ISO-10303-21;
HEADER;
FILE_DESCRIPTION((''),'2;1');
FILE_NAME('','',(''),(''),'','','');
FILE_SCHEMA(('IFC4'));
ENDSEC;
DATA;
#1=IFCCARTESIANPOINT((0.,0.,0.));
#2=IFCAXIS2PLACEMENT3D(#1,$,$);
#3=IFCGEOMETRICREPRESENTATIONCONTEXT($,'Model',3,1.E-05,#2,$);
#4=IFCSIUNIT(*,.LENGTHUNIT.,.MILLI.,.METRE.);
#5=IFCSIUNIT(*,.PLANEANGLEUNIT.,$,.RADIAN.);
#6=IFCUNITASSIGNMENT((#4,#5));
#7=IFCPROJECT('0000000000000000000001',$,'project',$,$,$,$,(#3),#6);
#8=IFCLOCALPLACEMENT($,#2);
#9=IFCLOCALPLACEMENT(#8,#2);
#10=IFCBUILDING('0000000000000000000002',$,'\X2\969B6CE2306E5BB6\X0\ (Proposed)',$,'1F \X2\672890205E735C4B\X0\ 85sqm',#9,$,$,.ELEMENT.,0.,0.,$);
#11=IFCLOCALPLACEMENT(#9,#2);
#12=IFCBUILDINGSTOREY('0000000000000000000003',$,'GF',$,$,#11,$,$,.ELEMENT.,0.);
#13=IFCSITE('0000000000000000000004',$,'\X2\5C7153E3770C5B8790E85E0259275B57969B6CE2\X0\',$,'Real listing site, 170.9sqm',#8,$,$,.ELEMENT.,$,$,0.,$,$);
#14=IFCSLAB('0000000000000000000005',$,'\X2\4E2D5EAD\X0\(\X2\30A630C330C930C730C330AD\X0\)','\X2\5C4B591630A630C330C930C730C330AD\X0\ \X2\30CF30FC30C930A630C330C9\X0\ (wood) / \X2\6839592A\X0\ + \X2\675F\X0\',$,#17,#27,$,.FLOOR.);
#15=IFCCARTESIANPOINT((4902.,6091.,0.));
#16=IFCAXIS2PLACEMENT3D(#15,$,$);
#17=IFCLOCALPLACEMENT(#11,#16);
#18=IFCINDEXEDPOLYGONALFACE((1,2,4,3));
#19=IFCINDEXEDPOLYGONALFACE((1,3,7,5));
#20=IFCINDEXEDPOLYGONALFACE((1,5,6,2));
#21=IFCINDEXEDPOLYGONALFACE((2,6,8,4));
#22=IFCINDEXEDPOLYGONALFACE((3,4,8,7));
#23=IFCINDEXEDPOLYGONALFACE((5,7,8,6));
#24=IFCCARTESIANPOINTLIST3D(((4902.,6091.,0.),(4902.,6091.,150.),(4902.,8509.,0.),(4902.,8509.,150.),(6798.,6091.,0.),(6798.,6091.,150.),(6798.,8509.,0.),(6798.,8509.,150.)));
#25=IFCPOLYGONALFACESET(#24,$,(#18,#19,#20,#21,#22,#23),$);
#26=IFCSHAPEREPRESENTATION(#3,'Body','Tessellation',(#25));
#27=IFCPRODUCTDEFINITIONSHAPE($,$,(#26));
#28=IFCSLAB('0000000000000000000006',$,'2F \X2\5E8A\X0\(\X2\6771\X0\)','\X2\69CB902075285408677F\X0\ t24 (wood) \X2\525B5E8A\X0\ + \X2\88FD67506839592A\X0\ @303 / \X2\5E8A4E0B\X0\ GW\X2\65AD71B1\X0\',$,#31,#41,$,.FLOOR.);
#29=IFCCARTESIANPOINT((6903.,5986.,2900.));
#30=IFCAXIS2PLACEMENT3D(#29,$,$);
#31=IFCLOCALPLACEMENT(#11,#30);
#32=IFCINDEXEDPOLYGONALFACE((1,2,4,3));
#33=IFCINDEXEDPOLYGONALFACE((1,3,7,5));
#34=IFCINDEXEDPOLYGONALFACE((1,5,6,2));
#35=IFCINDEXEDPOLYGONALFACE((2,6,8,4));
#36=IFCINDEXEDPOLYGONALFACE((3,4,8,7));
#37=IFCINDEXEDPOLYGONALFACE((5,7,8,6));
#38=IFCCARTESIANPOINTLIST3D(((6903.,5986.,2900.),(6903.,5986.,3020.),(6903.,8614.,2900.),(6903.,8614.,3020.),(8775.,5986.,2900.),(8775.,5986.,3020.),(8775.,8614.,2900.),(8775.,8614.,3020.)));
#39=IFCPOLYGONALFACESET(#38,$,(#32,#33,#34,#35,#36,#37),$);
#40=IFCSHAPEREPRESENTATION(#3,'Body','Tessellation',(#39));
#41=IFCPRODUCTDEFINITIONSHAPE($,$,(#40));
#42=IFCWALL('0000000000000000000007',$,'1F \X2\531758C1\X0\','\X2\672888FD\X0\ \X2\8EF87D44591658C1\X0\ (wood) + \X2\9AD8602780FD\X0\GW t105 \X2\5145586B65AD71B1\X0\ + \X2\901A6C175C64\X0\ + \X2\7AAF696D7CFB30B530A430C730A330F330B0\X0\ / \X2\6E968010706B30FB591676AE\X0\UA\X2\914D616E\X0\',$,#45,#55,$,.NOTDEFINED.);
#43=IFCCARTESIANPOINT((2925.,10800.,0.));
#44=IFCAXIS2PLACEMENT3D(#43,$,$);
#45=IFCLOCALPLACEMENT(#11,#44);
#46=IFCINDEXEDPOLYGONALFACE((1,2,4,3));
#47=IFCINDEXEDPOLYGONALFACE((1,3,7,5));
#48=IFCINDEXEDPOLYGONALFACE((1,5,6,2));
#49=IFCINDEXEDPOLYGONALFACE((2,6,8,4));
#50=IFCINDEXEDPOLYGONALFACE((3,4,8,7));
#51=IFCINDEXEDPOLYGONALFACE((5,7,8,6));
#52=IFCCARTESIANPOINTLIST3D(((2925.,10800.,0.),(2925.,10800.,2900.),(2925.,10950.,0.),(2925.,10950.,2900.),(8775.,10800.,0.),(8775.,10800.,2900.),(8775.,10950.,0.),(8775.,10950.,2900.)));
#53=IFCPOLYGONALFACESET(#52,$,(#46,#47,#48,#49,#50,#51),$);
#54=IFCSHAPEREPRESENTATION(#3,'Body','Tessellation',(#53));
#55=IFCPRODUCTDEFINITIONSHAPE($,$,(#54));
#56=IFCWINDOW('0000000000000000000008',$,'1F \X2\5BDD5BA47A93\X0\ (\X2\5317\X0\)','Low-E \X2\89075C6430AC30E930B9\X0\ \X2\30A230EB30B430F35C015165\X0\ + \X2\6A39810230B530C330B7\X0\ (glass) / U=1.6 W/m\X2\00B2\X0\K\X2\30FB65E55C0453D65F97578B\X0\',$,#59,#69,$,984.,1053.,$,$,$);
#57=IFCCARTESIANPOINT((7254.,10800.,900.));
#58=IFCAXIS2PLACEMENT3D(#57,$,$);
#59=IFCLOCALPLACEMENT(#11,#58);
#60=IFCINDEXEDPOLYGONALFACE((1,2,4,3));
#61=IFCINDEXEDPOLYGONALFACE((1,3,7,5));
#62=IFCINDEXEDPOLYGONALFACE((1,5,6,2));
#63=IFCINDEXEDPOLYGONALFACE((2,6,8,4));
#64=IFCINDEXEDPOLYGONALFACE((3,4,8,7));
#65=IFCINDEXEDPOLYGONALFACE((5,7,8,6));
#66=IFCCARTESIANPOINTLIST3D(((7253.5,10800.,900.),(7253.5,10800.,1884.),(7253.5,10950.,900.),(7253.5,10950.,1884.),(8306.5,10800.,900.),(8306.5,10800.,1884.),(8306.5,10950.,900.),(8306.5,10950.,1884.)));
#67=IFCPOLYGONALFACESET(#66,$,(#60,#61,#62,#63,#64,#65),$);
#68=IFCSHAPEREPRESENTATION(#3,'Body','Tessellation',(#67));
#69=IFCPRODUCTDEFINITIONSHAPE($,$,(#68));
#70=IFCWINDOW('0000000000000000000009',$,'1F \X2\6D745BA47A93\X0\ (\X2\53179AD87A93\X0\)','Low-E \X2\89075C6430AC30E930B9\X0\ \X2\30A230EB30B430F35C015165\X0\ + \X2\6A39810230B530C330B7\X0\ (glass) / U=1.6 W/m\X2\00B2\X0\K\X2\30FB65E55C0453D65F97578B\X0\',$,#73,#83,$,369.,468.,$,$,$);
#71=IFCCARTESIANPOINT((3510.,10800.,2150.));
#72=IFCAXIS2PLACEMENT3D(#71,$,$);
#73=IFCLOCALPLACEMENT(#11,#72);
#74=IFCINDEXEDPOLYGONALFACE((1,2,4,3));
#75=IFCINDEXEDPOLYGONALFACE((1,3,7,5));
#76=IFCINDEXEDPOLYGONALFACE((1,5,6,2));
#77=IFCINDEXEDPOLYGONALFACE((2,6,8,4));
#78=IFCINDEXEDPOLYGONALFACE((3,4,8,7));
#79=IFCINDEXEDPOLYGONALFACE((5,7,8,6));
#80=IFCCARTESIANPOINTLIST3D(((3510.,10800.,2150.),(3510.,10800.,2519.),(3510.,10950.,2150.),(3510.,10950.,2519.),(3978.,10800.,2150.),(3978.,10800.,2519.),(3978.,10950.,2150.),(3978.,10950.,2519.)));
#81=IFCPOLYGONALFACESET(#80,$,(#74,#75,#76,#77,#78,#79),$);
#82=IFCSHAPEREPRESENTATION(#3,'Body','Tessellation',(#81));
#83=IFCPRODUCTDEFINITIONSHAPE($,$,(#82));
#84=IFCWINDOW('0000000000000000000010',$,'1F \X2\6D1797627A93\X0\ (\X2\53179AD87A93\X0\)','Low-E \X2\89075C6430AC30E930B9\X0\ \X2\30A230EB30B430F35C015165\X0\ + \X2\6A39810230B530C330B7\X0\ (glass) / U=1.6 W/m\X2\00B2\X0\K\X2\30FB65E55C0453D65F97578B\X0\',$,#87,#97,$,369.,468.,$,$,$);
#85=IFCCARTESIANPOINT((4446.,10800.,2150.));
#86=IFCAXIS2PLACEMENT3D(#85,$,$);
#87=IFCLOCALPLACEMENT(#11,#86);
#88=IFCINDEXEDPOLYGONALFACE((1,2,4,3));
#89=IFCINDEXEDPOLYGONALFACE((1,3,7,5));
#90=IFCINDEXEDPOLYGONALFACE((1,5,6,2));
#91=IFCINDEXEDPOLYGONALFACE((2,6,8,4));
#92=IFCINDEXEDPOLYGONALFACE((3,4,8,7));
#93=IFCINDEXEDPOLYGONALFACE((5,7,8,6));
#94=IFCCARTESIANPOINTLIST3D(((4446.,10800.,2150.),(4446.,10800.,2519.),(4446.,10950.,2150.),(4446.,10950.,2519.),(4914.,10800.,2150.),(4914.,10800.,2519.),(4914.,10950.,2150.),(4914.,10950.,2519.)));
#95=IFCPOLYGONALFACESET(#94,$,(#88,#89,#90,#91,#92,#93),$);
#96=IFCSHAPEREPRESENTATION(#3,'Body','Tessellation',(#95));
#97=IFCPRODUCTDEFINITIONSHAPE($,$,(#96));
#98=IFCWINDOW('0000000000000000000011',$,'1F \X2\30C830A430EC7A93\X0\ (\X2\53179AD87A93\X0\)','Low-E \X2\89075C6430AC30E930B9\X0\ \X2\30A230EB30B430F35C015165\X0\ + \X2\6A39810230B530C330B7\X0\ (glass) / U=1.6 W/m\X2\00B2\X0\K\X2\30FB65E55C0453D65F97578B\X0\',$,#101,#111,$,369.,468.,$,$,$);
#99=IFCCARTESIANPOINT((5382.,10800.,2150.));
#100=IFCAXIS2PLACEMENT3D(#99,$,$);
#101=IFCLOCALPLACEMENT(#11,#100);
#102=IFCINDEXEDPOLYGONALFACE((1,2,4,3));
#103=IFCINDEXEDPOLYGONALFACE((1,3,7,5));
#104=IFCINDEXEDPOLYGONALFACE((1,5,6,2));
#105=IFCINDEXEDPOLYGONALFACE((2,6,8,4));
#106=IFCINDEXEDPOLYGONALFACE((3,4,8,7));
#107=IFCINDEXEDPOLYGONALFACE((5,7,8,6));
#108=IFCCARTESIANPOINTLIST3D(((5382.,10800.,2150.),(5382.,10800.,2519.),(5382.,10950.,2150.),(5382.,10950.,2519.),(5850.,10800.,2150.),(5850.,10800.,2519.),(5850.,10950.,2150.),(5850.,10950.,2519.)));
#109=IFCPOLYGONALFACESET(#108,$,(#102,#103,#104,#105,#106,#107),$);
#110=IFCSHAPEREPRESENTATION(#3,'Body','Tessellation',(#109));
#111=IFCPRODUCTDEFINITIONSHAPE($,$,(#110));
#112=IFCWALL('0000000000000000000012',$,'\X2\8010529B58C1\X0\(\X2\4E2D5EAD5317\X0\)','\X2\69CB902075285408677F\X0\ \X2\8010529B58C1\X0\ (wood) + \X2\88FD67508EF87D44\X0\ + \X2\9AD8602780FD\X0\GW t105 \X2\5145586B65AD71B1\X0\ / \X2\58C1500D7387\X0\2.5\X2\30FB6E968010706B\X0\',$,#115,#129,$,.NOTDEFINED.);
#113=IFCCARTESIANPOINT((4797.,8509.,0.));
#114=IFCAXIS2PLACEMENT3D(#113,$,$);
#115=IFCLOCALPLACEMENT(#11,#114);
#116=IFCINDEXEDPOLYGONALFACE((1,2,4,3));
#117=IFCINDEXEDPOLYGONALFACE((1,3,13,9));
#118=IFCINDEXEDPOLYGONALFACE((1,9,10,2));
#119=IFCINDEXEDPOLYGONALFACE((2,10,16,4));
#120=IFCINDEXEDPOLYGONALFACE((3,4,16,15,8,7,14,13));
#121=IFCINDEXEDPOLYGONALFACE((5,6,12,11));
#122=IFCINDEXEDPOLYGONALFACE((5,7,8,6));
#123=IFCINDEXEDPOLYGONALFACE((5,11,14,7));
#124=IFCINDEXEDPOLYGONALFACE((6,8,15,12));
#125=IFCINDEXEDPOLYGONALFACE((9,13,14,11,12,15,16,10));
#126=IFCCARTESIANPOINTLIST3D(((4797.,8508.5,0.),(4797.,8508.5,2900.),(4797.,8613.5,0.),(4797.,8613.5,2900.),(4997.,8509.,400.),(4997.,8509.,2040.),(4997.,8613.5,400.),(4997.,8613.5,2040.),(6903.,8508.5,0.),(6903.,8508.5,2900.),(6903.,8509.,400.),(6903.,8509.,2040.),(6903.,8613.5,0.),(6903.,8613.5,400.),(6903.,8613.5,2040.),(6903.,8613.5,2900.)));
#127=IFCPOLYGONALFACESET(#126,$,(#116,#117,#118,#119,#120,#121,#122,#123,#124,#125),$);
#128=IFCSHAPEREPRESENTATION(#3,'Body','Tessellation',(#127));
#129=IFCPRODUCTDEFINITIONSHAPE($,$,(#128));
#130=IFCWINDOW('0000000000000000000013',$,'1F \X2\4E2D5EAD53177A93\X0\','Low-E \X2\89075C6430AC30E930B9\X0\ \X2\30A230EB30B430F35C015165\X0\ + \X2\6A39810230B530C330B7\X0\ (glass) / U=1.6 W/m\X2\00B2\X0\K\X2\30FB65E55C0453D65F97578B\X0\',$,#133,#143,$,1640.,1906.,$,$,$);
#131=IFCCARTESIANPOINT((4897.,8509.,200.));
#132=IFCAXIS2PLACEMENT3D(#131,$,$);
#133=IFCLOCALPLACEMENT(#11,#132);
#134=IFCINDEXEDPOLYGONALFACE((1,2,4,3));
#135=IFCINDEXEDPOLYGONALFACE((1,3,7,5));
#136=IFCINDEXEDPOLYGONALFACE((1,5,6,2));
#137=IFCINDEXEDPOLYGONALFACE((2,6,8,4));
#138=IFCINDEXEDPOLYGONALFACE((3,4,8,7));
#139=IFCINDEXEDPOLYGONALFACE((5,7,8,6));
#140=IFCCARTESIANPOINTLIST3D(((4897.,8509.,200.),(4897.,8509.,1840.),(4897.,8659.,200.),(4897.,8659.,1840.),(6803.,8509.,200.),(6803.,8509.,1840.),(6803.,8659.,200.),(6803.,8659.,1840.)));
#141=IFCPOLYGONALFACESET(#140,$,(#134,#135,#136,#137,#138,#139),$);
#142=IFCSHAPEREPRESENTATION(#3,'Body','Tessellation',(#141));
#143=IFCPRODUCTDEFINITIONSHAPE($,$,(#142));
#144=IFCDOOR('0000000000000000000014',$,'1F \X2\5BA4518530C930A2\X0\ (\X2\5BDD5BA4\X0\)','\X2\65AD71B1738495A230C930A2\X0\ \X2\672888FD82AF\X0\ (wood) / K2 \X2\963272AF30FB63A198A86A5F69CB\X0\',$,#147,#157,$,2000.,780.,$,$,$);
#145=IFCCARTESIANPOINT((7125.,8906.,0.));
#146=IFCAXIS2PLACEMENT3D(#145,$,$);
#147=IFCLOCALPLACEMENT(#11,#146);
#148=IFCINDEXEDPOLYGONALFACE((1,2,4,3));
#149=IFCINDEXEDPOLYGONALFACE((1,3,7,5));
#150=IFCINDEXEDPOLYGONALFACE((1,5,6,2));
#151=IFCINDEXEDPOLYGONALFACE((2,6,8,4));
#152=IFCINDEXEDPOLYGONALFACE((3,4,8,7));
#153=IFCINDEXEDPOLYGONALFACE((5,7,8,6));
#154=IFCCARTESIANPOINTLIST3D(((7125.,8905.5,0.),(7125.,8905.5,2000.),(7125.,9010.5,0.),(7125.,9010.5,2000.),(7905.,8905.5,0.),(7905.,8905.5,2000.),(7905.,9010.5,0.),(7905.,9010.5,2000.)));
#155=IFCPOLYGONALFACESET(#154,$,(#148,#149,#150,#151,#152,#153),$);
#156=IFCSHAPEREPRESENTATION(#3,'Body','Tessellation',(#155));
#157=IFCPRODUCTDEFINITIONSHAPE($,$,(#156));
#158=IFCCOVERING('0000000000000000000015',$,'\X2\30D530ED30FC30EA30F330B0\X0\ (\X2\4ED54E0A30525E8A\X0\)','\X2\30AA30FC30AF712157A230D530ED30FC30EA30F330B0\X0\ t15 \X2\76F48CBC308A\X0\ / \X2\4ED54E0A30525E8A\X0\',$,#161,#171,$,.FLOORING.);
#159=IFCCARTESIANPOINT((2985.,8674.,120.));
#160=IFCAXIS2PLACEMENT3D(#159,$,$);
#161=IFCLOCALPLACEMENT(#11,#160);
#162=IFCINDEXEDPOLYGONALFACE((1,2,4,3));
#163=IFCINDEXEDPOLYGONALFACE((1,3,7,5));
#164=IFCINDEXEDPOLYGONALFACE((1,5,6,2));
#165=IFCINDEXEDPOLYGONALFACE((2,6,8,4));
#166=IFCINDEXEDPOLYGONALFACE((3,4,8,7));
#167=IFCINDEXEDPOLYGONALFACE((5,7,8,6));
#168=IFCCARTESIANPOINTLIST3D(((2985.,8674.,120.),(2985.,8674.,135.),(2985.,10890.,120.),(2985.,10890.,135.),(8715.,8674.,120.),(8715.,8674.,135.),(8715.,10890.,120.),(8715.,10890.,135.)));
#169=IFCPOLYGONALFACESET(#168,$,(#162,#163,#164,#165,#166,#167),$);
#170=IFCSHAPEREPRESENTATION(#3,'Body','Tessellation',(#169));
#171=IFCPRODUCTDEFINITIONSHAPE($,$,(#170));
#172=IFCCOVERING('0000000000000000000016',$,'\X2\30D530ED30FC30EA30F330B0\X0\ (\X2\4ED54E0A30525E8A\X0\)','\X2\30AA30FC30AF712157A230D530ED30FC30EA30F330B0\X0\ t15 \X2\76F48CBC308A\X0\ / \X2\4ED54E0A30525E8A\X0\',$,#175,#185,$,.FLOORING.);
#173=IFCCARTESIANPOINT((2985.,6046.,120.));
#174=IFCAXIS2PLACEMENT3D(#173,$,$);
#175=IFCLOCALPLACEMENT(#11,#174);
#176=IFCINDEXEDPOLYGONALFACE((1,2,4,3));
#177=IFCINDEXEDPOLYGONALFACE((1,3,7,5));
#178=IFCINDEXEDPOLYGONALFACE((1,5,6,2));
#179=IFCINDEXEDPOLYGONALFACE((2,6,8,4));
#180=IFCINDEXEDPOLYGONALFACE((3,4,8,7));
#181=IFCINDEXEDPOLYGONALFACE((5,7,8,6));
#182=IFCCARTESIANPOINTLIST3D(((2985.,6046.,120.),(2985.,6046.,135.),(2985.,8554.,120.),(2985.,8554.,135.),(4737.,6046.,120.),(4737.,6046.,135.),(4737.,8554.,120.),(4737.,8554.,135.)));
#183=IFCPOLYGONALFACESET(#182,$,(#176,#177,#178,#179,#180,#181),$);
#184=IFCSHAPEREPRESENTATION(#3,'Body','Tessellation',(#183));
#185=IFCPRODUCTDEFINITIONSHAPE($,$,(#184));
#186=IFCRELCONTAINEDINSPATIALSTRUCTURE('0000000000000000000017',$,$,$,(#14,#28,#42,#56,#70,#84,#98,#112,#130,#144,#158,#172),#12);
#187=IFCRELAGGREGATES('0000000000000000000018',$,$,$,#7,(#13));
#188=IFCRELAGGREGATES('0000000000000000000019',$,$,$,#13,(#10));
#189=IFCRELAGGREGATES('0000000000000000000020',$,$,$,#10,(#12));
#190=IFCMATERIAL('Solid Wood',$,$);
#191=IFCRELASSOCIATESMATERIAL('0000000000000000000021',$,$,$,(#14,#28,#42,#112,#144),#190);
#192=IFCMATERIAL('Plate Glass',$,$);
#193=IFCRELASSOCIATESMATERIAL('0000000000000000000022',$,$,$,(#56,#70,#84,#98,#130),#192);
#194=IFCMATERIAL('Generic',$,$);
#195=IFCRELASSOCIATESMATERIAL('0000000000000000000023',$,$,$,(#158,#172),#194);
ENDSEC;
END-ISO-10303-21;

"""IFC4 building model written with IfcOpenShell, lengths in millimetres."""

from ifc_helpers import new_model, si_unit, frame, frame_2d, origin, place, context, project, spatial, rectangle, extrude, material, element, fill, save


model = new_model("IFC4")

# Units and contexts
model_context = context("Model", 3, precision=1e-05, world=origin())
ifc_project = project(units=[si_unit("LENGTHUNIT", "METRE", prefix="MILLI"), si_unit("PLANEANGLEUNIT", "RADIAN")], contexts=[model_context])

# Site, building, storey
site_placement = place(None, origin())
site = spatial("IfcSite", under=ifc_project, at=site_placement, Name="山口県宇部市大字際波", ObjectType="Real listing site, 170.9sqm", CompositionType="ELEMENT", RefElevation=0.0)
building_placement = place(site_placement, origin())
building = spatial("IfcBuilding", under=site, at=building_placement, Name="際波の家 (Proposed)", ObjectType="1F 木造平屋 85sqm", CompositionType="ELEMENT", ElevationOfRefHeight=0.0, ElevationOfTerrain=0.0)
storey_placement = place(building_placement, origin())
storey = spatial("IfcBuildingStorey", under=building, at=storey_placement, Name="GF", CompositionType="ELEMENT", Elevation=0.0)

# Slabs
ifc_material_1 = material(Name="Solid Wood")
slab_1_placement = place(storey_placement, frame((4902.0, 6091.0, 0.0)))
element("IfcSlab", 1, at=slab_1_placement, inside=storey, material=ifc_material_1, Name="中庭(ウッドデッキ)", Description="屋外ウッドデッキ ハードウッド (wood) / 根太 + 束", PredefinedType="FLOOR", context=model_context, shape_type="SweptSolid", body=[
    extrude(rectangle(XDim=1896.0, YDim=2418.0, at=frame_2d((948.0, 1209.0))), frame((4902.0, 6091.0, 0.0)), (0.0, 0.0, 1.0), 150.0),
])
slab_2_placement = place(storey_placement, frame((6903.0, 5986.0, 2900.0)))
element("IfcSlab", 2, at=slab_2_placement, inside=storey, material=ifc_material_1, Name="2F 床(東)", Description="構造用合板 t24 (wood) 剛床 + 製材根太 @303 / 床下 GW断熱", PredefinedType="FLOOR", context=model_context, shape_type="SweptSolid", body=[
    extrude(rectangle(XDim=1872.0, YDim=2628.0, at=frame_2d((936.0, 1314.0))), frame((6903.0, 5986.0, 2900.0)), (0.0, 0.0, 1.0), 120.0),
])

# Wall, openings, windows
wall_1_placement = place(storey_placement, frame((2925.0, 10800.0, 0.0)))
wall_1 = element("IfcWall", 3, at=wall_1_placement, inside=storey, material=ifc_material_1, Name="1F 北壁", Description="木製 軸組外壁 (wood) + 高性能GW t105 充填断熱 + 通気層 + 窯業系サイディング / 準耐火・外皮UA配慮", PredefinedType="NOTDEFINED", context=model_context, shape_type="SweptSolid", body=[
    extrude(rectangle(XDim=5850.0, YDim=150.0, at=frame_2d((2925.0, 75.0))), frame((2925.0, 10800.0, 0.0)), (0.0, 0.0, 1.0), 2900.0),
])
opening_1_placement = place(storey_placement, frame((7254.0, 10800.0, 900.0)))
opening_1 = element("IfcOpeningElement", 4, at=opening_1_placement, cuts=wall_1, PredefinedType="NOTDEFINED", context=model_context, shape_type="SweptSolid", body=[
    extrude(rectangle(XDim=1053.0, YDim=150.0, at=frame_2d((526.0, 75.0))), frame((7254.0, 10800.0, 900.0)), (0.0, 0.0, 1.0), 984.0),
])
opening_2_placement = place(storey_placement, frame((3510.0, 10800.0, 2150.0)))
opening_2 = element("IfcOpeningElement", 5, at=opening_2_placement, cuts=wall_1, PredefinedType="NOTDEFINED", context=model_context, shape_type="SweptSolid", body=[
    extrude(rectangle(XDim=468.0, YDim=150.0, at=frame_2d((234.0, 75.0))), frame((3510.0, 10800.0, 2150.0)), (0.0, 0.0, 1.0), 369.0),
])
opening_3_placement = place(storey_placement, frame((4446.0, 10800.0, 2150.0)))
opening_3 = element("IfcOpeningElement", 6, at=opening_3_placement, cuts=wall_1, PredefinedType="NOTDEFINED", context=model_context, shape_type="SweptSolid", body=[
    extrude(rectangle(XDim=468.0, YDim=150.0, at=frame_2d((234.0, 75.0))), frame((4446.0, 10800.0, 2150.0)), (0.0, 0.0, 1.0), 369.0),
])
opening_4_placement = place(storey_placement, frame((5382.0, 10800.0, 2150.0)))
opening_4 = element("IfcOpeningElement", 7, at=opening_4_placement, cuts=wall_1, PredefinedType="NOTDEFINED", context=model_context, shape_type="SweptSolid", body=[
    extrude(rectangle(XDim=468.0, YDim=150.0, at=frame_2d((234.0, 75.0))), frame((5382.0, 10800.0, 2150.0)), (0.0, 0.0, 1.0), 369.0),
])
ifc_material_2 = material(Name="Plate Glass")
window_1_placement = place(storey_placement, frame((7254.0, 10800.0, 900.0)))
window_1 = element("IfcWindow", 8, at=window_1_placement, inside=storey, material=ifc_material_2, Name="1F 寝室窓 (北)", Description="Low-E 複層ガラス アルゴン封入 + 樹脂サッシ (glass) / U=1.6 W/m²K・日射取得型", OverallHeight=984.0, OverallWidth=1053.0, context=model_context, shape_type="SweptSolid", body=[
    extrude(rectangle(XDim=1053.0, YDim=150.0, at=frame_2d((526.0, 75.0))), frame((7254.0, 10800.0, 900.0)), (0.0, 0.0, 1.0), 984.0),
])
fill(opening_1, window_1)
window_2_placement = place(storey_placement, frame((3510.0, 10800.0, 2150.0)))
window_2 = element("IfcWindow", 9, at=window_2_placement, inside=storey, material=ifc_material_2, Name="1F 浴室窓 (北高窓)", Description="Low-E 複層ガラス アルゴン封入 + 樹脂サッシ (glass) / U=1.6 W/m²K・日射取得型", OverallHeight=369.0, OverallWidth=468.0, context=model_context, shape_type="SweptSolid", body=[
    extrude(rectangle(XDim=468.0, YDim=150.0, at=frame_2d((234.0, 75.0))), frame((3510.0, 10800.0, 2150.0)), (0.0, 0.0, 1.0), 369.0),
])
fill(opening_2, window_2)
window_3_placement = place(storey_placement, frame((4446.0, 10800.0, 2150.0)))
window_3 = element("IfcWindow", 10, at=window_3_placement, inside=storey, material=ifc_material_2, Name="1F 洗面窓 (北高窓)", Description="Low-E 複層ガラス アルゴン封入 + 樹脂サッシ (glass) / U=1.6 W/m²K・日射取得型", OverallHeight=369.0, OverallWidth=468.0, context=model_context, shape_type="SweptSolid", body=[
    extrude(rectangle(XDim=468.0, YDim=150.0, at=frame_2d((234.0, 75.0))), frame((4446.0, 10800.0, 2150.0)), (0.0, 0.0, 1.0), 369.0),
])
fill(opening_3, window_3)
window_4_placement = place(storey_placement, frame((5382.0, 10800.0, 2150.0)))
window_4 = element("IfcWindow", 11, at=window_4_placement, inside=storey, material=ifc_material_2, Name="1F トイレ窓 (北高窓)", Description="Low-E 複層ガラス アルゴン封入 + 樹脂サッシ (glass) / U=1.6 W/m²K・日射取得型", OverallHeight=369.0, OverallWidth=468.0, context=model_context, shape_type="SweptSolid", body=[
    extrude(rectangle(XDim=468.0, YDim=150.0, at=frame_2d((234.0, 75.0))), frame((5382.0, 10800.0, 2150.0)), (0.0, 0.0, 1.0), 369.0),
])
fill(opening_4, window_4)

# Wall, opening, window
wall_2_placement = place(storey_placement, frame((4797.0, 8509.0, 0.0)))
wall_2 = element("IfcWall", 12, at=wall_2_placement, inside=storey, material=ifc_material_1, Name="耐力壁(中庭北)", Description="構造用合板 耐力壁 (wood) + 製材軸組 + 高性能GW t105 充填断熱 / 壁倍率2.5・準耐火", PredefinedType="NOTDEFINED", context=model_context, shape_type="SweptSolid", body=[
    extrude(rectangle(XDim=2106.0, YDim=105.0, at=frame_2d((1053.0, 52.0))), frame((4797.0, 8509.0, 0.0)), (0.0, 0.0, 1.0), 2900.0),
])
opening_5_placement = place(storey_placement, frame((4897.0, 8509.0, 200.0)))
opening_5 = element("IfcOpeningElement", 13, at=opening_5_placement, cuts=wall_2, PredefinedType="NOTDEFINED", context=model_context, shape_type="SweptSolid", body=[
    extrude(rectangle(XDim=1906.0, YDim=150.0, at=frame_2d((953.0, 75.0))), frame((4897.0, 8509.0, 200.0)), (0.0, 0.0, 1.0), 1640.0),
])
window_5_placement = place(storey_placement, frame((4897.0, 8509.0, 200.0)))
window_5 = element("IfcWindow", 14, at=window_5_placement, inside=storey, material=ifc_material_2, Name="1F 中庭北窓", Description="Low-E 複層ガラス アルゴン封入 + 樹脂サッシ (glass) / U=1.6 W/m²K・日射取得型", OverallHeight=1640.0, OverallWidth=1906.0, context=model_context, shape_type="SweptSolid", body=[
    extrude(rectangle(XDim=1906.0, YDim=150.0, at=frame_2d((953.0, 75.0))), frame((4897.0, 8509.0, 200.0)), (0.0, 0.0, 1.0), 1640.0),
])
fill(opening_5, window_5)

# Door
door_1_placement = place(storey_placement, frame((7125.0, 8906.0, 0.0)))
element("IfcDoor", 15, at=door_1_placement, inside=storey, material=ifc_material_1, Name="1F 室内ドア (寝室)", Description="断熱玄関ドア 木製芯 (wood) / K2 防犯・採風機構", OverallHeight=2000.0, OverallWidth=780.0, context=model_context, shape_type="SweptSolid", body=[
    extrude(rectangle(XDim=780.0, YDim=105.0, at=frame_2d((390.0, 52.0))), frame((7125.0, 8906.0, 0.0)), (0.0, 0.0, 1.0), 2000.0),
])

# Coverings
ifc_material_3 = material(Name="Generic")
covering_1_placement = place(storey_placement, frame((2985.0, 8674.0, 120.0)))
element("IfcCovering", 16, at=covering_1_placement, inside=storey, material=ifc_material_3, Name="フローリング (仕上げ床)", Description="オーク無垢フローリング t15 直貼り / 仕上げ床", PredefinedType="FLOORING", context=model_context, shape_type="SweptSolid", body=[
    extrude(rectangle(XDim=5730.0, YDim=2216.0, at=frame_2d((2865.0, 1108.0))), frame((2985.0, 8674.0, 120.0)), (0.0, 0.0, 1.0), 15.0),
])
covering_2_placement = place(storey_placement, frame((2985.0, 6046.0, 120.0)))
element("IfcCovering", 17, at=covering_2_placement, inside=storey, material=ifc_material_3, Name="フローリング (仕上げ床)", Description="オーク無垢フローリング t15 直貼り / 仕上げ床", PredefinedType="FLOORING", context=model_context, shape_type="SweptSolid", body=[
    extrude(rectangle(XDim=1752.0, YDim=2508.0, at=frame_2d((876.0, 1254.0))), frame((2985.0, 6046.0, 120.0)), (0.0, 0.0, 1.0), 15.0),
])

save(model, "model.ifc")
